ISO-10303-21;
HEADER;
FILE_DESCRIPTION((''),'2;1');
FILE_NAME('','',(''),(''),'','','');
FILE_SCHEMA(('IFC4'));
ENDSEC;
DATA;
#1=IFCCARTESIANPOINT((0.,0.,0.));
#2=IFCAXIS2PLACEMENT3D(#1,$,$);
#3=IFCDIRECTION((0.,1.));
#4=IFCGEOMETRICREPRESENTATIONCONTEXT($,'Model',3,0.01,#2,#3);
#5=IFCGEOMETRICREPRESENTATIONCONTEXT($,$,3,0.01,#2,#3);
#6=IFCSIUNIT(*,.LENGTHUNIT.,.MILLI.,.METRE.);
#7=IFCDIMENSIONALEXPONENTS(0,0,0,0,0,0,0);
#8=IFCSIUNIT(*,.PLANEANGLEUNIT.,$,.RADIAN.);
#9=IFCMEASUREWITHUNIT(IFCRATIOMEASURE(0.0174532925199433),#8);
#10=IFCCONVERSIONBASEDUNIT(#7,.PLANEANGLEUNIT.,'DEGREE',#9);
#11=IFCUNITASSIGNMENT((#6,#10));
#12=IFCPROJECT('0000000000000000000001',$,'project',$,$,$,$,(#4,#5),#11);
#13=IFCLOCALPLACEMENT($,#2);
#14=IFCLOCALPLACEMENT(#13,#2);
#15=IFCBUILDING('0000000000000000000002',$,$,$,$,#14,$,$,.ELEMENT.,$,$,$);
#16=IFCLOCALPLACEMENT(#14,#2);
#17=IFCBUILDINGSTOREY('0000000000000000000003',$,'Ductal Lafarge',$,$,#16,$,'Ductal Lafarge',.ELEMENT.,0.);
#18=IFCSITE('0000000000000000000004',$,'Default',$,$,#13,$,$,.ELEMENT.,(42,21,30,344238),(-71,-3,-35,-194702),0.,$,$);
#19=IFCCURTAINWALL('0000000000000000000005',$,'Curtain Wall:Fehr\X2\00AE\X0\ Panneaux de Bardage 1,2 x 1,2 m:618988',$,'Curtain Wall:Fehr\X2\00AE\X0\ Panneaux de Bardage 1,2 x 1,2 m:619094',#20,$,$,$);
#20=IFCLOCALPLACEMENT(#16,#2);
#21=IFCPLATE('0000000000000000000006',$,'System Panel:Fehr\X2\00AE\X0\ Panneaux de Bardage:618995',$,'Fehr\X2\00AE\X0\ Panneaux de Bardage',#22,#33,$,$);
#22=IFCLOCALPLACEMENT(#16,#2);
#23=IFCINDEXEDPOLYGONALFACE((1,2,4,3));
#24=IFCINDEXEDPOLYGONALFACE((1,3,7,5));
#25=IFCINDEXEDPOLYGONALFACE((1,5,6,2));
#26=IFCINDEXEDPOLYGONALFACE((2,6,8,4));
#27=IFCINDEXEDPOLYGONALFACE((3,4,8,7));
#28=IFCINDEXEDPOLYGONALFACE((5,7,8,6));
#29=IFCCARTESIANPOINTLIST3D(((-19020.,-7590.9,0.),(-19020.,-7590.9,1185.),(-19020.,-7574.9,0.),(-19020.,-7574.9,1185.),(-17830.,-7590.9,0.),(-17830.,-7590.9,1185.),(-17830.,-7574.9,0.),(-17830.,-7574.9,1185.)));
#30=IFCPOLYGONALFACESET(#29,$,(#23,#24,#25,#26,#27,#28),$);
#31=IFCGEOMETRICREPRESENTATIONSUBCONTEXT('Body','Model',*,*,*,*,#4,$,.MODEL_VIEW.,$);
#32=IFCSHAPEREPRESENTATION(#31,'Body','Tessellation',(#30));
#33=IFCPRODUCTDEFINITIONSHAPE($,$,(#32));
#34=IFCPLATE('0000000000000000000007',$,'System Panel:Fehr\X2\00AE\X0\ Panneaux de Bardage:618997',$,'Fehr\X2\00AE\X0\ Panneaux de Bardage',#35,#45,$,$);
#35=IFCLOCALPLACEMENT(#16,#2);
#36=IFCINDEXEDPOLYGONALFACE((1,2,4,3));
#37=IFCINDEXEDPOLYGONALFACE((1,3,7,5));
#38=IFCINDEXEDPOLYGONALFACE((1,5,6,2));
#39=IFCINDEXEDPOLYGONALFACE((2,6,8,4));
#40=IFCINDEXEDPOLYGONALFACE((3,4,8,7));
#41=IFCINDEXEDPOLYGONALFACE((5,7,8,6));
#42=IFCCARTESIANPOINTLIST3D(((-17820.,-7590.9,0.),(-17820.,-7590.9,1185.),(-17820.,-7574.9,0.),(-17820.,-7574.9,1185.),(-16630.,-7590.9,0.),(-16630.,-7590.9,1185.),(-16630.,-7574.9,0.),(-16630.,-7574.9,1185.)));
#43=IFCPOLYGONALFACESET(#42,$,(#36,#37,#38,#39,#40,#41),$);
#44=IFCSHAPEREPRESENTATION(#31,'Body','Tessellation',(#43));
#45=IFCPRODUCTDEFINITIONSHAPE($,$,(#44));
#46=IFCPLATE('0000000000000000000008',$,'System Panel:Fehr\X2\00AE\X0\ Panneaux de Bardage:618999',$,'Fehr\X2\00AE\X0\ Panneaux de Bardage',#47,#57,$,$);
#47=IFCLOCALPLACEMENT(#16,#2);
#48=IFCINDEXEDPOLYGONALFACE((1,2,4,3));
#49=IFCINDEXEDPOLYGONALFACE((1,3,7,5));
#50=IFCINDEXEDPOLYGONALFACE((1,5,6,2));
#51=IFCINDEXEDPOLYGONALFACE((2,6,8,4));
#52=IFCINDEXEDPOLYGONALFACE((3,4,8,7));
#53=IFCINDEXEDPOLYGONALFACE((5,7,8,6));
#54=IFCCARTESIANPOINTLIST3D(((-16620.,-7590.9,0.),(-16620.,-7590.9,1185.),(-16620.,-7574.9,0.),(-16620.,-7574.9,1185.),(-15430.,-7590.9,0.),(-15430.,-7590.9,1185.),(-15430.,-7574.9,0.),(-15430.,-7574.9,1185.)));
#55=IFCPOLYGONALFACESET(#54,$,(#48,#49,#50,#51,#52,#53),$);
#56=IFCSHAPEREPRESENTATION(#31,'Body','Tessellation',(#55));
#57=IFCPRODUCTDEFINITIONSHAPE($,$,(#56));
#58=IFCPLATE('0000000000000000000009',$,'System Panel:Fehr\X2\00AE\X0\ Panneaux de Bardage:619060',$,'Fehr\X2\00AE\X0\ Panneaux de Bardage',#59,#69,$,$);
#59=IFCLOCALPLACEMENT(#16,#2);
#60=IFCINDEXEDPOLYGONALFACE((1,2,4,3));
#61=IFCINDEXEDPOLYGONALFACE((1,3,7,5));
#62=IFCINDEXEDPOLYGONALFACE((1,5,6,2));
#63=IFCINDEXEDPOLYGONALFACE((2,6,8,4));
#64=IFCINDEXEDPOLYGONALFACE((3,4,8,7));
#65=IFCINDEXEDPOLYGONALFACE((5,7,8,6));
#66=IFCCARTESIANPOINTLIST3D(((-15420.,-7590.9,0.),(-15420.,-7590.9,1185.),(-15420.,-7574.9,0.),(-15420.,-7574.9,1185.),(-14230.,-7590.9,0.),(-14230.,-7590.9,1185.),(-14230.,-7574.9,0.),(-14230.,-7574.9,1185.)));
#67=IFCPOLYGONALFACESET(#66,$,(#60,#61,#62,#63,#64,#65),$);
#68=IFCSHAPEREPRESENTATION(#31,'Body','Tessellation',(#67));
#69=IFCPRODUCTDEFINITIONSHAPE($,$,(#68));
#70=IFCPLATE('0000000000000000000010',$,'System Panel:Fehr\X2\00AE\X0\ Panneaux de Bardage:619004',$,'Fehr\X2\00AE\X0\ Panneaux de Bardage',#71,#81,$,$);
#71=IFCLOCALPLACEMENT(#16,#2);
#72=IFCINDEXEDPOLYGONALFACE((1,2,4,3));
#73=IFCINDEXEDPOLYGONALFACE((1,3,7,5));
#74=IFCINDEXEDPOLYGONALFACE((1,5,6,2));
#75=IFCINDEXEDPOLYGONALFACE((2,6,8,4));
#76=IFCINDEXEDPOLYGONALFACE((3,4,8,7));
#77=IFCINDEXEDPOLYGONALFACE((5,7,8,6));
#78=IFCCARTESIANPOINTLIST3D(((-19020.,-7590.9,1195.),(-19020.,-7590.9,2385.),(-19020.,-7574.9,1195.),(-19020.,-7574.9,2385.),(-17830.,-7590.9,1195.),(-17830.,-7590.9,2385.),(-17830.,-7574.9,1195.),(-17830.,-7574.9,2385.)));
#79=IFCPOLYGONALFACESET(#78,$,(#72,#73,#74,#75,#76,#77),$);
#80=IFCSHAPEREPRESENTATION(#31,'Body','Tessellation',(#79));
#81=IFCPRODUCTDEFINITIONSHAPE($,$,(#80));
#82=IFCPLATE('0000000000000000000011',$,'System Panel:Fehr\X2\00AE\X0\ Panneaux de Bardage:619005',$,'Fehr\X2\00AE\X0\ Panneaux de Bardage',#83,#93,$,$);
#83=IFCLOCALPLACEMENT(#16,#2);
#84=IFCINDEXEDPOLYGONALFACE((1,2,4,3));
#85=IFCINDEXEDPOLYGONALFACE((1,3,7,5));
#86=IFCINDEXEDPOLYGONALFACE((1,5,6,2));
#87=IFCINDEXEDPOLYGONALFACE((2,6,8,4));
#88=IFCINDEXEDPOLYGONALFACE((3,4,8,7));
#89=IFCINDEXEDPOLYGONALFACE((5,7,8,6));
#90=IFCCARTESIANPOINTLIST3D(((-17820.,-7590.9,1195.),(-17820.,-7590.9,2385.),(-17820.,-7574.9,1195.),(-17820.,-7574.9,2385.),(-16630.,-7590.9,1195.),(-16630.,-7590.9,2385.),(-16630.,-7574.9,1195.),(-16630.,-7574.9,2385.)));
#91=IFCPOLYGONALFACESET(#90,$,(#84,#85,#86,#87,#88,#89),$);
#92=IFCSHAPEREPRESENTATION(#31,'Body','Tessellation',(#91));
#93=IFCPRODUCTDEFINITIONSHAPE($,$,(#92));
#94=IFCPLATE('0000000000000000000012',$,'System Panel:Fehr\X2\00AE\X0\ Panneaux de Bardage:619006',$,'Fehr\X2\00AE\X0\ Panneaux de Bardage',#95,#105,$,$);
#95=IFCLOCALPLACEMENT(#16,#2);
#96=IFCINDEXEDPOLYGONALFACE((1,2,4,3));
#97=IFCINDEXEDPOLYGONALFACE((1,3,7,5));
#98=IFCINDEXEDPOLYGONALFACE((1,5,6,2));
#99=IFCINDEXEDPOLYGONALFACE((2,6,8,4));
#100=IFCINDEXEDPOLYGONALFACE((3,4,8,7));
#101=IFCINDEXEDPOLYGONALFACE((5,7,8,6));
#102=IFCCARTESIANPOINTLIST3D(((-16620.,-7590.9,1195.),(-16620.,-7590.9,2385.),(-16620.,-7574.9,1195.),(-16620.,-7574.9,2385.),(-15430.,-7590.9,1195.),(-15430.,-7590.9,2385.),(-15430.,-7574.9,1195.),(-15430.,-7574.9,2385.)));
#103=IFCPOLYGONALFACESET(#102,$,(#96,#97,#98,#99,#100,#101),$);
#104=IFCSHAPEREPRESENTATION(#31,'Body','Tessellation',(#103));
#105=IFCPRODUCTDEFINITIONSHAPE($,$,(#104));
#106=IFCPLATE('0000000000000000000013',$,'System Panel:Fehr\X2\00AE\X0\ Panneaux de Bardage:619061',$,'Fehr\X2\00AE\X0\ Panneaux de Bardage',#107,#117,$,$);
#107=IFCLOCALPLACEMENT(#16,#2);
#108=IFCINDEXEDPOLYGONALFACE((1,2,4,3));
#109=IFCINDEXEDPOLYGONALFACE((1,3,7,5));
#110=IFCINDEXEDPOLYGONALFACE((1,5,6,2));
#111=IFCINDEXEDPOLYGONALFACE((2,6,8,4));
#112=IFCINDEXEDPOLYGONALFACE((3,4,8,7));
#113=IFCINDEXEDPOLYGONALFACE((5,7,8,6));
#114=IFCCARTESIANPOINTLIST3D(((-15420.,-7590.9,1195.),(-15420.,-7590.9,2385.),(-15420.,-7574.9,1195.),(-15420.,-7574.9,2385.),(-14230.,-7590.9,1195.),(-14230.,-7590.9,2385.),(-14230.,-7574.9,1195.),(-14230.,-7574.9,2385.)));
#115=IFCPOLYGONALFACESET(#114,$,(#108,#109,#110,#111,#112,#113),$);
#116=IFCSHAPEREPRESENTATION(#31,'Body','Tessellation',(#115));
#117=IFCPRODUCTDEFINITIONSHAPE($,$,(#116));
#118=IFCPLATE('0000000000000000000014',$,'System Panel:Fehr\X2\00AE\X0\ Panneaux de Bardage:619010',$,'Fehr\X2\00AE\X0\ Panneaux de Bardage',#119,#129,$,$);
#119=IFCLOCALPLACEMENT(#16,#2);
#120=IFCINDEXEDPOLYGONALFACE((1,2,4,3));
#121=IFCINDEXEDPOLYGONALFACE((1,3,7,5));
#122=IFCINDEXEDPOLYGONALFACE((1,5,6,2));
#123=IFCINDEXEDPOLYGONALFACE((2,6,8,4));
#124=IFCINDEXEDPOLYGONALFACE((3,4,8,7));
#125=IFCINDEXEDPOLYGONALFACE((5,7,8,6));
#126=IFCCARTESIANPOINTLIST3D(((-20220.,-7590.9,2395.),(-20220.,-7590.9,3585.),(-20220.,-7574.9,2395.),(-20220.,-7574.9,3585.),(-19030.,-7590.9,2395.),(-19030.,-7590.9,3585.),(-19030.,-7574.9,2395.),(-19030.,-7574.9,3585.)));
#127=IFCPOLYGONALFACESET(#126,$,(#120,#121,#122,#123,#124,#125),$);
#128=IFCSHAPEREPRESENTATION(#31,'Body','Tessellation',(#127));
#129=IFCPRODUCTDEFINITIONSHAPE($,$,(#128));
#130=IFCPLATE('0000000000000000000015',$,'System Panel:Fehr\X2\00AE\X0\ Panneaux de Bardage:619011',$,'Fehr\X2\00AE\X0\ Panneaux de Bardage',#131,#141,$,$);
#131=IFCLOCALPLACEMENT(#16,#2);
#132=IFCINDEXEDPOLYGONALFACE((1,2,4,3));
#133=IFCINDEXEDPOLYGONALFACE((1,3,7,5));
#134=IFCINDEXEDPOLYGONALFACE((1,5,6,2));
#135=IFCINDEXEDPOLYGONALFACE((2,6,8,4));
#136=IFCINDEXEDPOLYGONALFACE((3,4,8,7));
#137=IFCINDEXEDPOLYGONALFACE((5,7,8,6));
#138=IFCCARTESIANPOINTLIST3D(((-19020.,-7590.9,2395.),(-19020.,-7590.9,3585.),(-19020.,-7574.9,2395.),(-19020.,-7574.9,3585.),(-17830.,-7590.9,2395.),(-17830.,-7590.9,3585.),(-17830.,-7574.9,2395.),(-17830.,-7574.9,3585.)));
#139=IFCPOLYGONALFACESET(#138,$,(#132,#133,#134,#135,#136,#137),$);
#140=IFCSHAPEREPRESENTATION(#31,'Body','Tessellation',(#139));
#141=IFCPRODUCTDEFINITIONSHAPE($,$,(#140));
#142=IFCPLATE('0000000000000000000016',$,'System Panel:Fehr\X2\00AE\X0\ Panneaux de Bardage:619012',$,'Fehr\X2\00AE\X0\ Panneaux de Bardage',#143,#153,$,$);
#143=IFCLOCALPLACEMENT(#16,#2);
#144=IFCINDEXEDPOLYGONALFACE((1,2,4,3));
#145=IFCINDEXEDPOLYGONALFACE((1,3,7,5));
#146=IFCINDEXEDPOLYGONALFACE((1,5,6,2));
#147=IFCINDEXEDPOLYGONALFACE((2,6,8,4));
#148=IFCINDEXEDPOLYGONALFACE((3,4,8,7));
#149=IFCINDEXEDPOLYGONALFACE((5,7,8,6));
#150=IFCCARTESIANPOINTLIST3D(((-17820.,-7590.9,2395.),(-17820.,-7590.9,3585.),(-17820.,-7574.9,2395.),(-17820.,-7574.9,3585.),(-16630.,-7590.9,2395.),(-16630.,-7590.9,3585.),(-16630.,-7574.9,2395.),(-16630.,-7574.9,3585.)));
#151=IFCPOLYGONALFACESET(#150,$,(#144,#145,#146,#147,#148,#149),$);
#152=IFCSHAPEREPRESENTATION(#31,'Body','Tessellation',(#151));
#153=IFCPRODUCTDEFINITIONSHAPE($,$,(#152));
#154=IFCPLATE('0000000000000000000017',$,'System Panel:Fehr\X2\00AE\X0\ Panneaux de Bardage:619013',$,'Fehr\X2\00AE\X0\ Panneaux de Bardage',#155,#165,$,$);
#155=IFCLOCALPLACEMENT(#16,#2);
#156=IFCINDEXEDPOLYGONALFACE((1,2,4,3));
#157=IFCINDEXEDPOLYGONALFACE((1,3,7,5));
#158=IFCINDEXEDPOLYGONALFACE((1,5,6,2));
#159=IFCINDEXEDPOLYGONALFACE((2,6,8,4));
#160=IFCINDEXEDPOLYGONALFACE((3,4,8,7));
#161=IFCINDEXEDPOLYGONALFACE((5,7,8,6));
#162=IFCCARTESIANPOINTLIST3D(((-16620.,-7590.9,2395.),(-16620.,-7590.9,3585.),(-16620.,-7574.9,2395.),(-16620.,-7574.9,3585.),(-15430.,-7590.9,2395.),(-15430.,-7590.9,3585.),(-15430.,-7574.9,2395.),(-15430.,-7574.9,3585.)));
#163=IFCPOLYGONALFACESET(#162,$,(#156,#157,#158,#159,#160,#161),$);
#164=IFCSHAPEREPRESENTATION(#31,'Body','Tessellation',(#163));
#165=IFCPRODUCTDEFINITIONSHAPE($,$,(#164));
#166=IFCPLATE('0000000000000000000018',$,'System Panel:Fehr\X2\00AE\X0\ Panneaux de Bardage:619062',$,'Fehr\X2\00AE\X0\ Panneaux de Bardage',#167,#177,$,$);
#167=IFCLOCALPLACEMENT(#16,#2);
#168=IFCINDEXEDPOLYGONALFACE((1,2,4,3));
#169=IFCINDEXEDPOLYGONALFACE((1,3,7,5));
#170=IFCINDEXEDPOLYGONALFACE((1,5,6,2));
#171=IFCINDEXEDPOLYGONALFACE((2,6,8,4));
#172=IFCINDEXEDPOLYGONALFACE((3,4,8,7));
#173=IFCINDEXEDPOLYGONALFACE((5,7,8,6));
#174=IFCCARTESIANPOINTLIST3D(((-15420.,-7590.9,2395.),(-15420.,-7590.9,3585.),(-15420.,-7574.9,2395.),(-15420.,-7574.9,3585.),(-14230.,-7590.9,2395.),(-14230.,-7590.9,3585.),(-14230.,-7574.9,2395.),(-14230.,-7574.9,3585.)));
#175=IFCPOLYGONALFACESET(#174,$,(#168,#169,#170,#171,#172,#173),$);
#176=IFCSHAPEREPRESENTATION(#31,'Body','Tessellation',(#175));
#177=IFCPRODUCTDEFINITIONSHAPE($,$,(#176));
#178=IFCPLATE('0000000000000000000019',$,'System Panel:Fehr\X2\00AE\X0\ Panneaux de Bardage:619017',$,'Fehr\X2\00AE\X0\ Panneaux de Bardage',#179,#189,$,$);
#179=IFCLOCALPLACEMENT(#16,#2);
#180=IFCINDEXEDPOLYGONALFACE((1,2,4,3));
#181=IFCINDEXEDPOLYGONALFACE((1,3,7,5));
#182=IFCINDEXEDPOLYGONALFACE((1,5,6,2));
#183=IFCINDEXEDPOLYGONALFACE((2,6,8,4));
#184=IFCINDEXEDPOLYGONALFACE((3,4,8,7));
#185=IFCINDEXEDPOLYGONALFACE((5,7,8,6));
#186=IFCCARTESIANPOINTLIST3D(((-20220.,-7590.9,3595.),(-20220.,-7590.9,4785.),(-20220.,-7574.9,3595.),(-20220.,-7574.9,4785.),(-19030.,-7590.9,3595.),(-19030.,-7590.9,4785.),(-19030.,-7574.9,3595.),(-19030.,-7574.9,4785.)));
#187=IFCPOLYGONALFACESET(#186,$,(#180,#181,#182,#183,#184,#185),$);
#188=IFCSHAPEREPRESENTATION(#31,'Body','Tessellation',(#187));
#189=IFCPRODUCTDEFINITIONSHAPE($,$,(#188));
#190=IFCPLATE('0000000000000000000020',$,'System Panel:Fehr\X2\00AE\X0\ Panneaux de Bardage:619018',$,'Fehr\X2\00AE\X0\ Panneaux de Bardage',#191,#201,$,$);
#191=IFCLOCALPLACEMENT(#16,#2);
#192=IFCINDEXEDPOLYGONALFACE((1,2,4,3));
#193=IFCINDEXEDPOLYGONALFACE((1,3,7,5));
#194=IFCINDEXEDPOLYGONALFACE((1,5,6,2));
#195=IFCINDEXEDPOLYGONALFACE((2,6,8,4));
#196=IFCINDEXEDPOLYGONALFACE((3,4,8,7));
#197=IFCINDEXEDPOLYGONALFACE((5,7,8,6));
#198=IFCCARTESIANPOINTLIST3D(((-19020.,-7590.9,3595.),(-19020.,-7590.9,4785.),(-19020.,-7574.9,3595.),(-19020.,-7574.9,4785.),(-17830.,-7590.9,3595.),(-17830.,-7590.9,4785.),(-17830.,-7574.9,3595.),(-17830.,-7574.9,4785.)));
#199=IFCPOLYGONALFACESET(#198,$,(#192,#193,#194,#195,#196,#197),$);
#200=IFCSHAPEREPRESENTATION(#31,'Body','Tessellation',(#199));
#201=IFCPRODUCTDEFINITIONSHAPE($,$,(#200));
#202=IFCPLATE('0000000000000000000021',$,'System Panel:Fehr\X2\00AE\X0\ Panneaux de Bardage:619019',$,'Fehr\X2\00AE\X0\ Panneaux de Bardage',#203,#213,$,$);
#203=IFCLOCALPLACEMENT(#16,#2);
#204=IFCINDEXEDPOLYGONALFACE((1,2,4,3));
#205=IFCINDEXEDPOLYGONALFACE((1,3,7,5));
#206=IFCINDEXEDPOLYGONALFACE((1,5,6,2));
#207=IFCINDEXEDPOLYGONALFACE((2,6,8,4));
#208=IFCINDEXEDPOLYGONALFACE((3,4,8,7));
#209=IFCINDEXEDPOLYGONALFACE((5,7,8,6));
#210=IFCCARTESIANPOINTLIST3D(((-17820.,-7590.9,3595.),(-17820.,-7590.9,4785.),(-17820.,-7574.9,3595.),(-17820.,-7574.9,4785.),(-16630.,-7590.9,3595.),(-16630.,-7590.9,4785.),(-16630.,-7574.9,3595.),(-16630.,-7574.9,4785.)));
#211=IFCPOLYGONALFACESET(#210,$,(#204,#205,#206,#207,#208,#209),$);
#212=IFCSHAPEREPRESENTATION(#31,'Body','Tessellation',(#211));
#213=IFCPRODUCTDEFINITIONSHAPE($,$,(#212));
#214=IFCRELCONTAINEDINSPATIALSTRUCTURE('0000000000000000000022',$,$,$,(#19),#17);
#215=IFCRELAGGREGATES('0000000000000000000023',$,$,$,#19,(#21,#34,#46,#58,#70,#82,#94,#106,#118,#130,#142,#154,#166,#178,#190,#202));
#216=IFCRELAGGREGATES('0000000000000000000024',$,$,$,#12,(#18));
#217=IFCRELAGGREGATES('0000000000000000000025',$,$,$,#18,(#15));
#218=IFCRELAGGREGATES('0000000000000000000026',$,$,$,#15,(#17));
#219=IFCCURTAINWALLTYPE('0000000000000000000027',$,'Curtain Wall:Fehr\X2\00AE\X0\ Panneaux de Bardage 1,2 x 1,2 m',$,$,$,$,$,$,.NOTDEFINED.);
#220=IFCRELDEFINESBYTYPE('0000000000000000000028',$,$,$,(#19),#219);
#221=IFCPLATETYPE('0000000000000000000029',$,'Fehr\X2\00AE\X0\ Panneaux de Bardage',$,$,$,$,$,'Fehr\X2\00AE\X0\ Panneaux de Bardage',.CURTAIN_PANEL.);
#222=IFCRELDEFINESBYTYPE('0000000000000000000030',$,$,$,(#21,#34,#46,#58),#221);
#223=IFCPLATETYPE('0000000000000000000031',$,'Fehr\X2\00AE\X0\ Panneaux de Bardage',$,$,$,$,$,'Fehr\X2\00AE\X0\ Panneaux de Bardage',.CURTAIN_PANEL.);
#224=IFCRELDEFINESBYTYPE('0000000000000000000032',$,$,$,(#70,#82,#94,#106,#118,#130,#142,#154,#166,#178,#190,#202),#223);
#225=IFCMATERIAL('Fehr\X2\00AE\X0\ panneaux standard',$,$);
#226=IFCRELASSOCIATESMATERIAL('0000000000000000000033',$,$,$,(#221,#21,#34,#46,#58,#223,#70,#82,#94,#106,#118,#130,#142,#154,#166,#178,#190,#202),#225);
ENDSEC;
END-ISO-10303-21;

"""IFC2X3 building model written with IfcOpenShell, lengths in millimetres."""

from ifc_helpers import new_model, entity, si_unit, converted_unit, direction, frame, origin, origin_2d_with_axis, place, context, subcontext, project, spatial, rectangle, extrude, source, transform, mapped, material, type_object, type_shapes, element, aggregate, save


model = new_model("IFC2X3")

# Units and contexts
model_context = context("Model", 3, precision=0.01, world=origin(), true_north=direction((0.0, 1.0)))
context_of_model = context(None, 3, precision=0.01, world=origin(), true_north=direction((0.0, 1.0)))
body_context = subcontext(model_context, "Body", "Model", "MODEL_VIEW")
ifc_project = project(units=[si_unit("LENGTHUNIT", "METRE", prefix="MILLI"), converted_unit("PLANEANGLEUNIT", "DEGREE", entity("IfcRatioMeasure", 0.0174532925199433), si_unit("PLANEANGLEUNIT", "RADIAN"), dimensions=[0, 0, 0, 0, 0, 0, 0])], contexts=[model_context, context_of_model])

# Site, building, storey
site_placement = place(None, origin())
site = spatial("IfcSite", under=ifc_project, at=site_placement, Name="Default", CompositionType="ELEMENT", RefLatitude=(42, 21, 30, 344238), RefLongitude=(-71, -3, -35, -194702), RefElevation=0.0)
building_placement = place(site_placement, origin())
building = spatial("IfcBuilding", under=site, at=building_placement, CompositionType="ELEMENT")
storey_placement = place(building_placement, origin())
storey = spatial("IfcBuildingStorey", under=building, at=storey_placement, Name="Ductal Lafarge", LongName="Ductal Lafarge", CompositionType="ELEMENT", Elevation=0.0)

# Curtain wall, plates
curtain_wall_type = type_object("IfcCurtainWallType", Name="Curtain Wall:Fehr® Panneaux de Bardage 1,2 x 1,2 m", PredefinedType="NOTDEFINED")
curtain_wall_placement = place(storey_placement, origin())
curtain_wall = element("IfcCurtainWall", 1, at=curtain_wall_placement, inside=storey, type_object=curtain_wall_type, Name="Curtain Wall:Fehr® Panneaux de Bardage 1,2 x 1,2 m:618988", ObjectType="Curtain Wall:Fehr® Panneaux de Bardage 1,2 x 1,2 m:619094")
ifc_material_1 = material(Name="Fehr® panneaux standard")
plate_type_1 = type_object("IfcPlateType", Name="Fehr® Panneaux de Bardage", ElementType="Fehr® Panneaux de Bardage", PredefinedType="CURTAIN_PANEL", material=ifc_material_1)
shared_shape_1 = source(origin(), body_context, "Body", "SweptSolid", [
    extrude(rectangle(XDim=16.0, YDim=1190.0, at=origin_2d_with_axis()), frame((0.0, 0.0, 0.0), z_axis=(0.0, 0.0, 1.0), x_axis=(0.0, 1.0, 0.0)), (0.0, 0.0, 1.0), 1185.0),
])
type_shapes(plate_type_1, [shared_shape_1])
plate_1_placement = place(curtain_wall_placement, frame((-18425.0, -7582.9, 0.0)))
plate_1 = element("IfcPlate", 2, at=plate_1_placement, type_object=plate_type_1, material=ifc_material_1, Name="System Panel:Fehr® Panneaux de Bardage:618995", ObjectType="Fehr® Panneaux de Bardage", context=body_context, shape_type="MappedRepresentation", body=[
    mapped(shared_shape_1, transform((0.0, 0.0, 0.0), scale=1.0)),
])
plate_2_placement = place(curtain_wall_placement, frame((-17225.0, -7582.9, 0.0)))
plate_2 = element("IfcPlate", 3, at=plate_2_placement, type_object=plate_type_1, material=ifc_material_1, Name="System Panel:Fehr® Panneaux de Bardage:618997", ObjectType="Fehr® Panneaux de Bardage", context=body_context, shape_type="MappedRepresentation", body=[
    mapped(shared_shape_1, transform((0.0, 0.0, 0.0), scale=1.0)),
])
plate_3_placement = place(curtain_wall_placement, frame((-16025.0, -7582.9, 0.0)))
plate_3 = element("IfcPlate", 4, at=plate_3_placement, type_object=plate_type_1, material=ifc_material_1, Name="System Panel:Fehr® Panneaux de Bardage:618999", ObjectType="Fehr® Panneaux de Bardage", context=body_context, shape_type="MappedRepresentation", body=[
    mapped(shared_shape_1, transform((0.0, 0.0, 0.0), scale=1.0)),
])
plate_4_placement = place(curtain_wall_placement, frame((-14825.0, -7582.9, 0.0)))
plate_4 = element("IfcPlate", 5, at=plate_4_placement, type_object=plate_type_1, material=ifc_material_1, Name="System Panel:Fehr® Panneaux de Bardage:619060", ObjectType="Fehr® Panneaux de Bardage", context=body_context, shape_type="MappedRepresentation", body=[
    mapped(shared_shape_1, transform((0.0, 0.0, 0.0), scale=1.0)),
])
plate_type_2 = type_object("IfcPlateType", Name="Fehr® Panneaux de Bardage", ElementType="Fehr® Panneaux de Bardage", PredefinedType="CURTAIN_PANEL", material=ifc_material_1)
shared_shape_2 = source(origin(), body_context, "Body", "SweptSolid", [
    extrude(rectangle(XDim=16.0, YDim=1190.0, at=origin_2d_with_axis()), frame((0.0, 0.0, 0.0), z_axis=(0.0, 0.0, 1.0), x_axis=(0.0, 1.0, 0.0)), (0.0, 0.0, 1.0), 1190.0),
])
type_shapes(plate_type_2, [shared_shape_2])
plate_5_placement = place(curtain_wall_placement, frame((-18425.0, -7582.9, 1195.0)))
plate_5 = element("IfcPlate", 6, at=plate_5_placement, type_object=plate_type_2, material=ifc_material_1, Name="System Panel:Fehr® Panneaux de Bardage:619004", ObjectType="Fehr® Panneaux de Bardage", context=body_context, shape_type="MappedRepresentation", body=[
    mapped(shared_shape_2, transform((0.0, 0.0, 0.0), scale=1.0)),
])
plate_6_placement = place(curtain_wall_placement, frame((-17225.0, -7582.9, 1195.0)))
plate_6 = element("IfcPlate", 7, at=plate_6_placement, type_object=plate_type_2, material=ifc_material_1, Name="System Panel:Fehr® Panneaux de Bardage:619005", ObjectType="Fehr® Panneaux de Bardage", context=body_context, shape_type="MappedRepresentation", body=[
    mapped(shared_shape_2, transform((0.0, 0.0, 0.0), scale=1.0)),
])
plate_7_placement = place(curtain_wall_placement, frame((-16025.0, -7582.9, 1195.0)))
plate_7 = element("IfcPlate", 8, at=plate_7_placement, type_object=plate_type_2, material=ifc_material_1, Name="System Panel:Fehr® Panneaux de Bardage:619006", ObjectType="Fehr® Panneaux de Bardage", context=body_context, shape_type="MappedRepresentation", body=[
    mapped(shared_shape_2, transform((0.0, 0.0, 0.0), scale=1.0)),
])
plate_8_placement = place(curtain_wall_placement, frame((-14825.0, -7582.9, 1195.0)))
plate_8 = element("IfcPlate", 9, at=plate_8_placement, type_object=plate_type_2, material=ifc_material_1, Name="System Panel:Fehr® Panneaux de Bardage:619061", ObjectType="Fehr® Panneaux de Bardage", context=body_context, shape_type="MappedRepresentation", body=[
    mapped(shared_shape_2, transform((0.0, 0.0, 0.0), scale=1.0)),
])
plate_9_placement = place(curtain_wall_placement, frame((-19625.0, -7582.9, 2395.0)))
plate_9 = element("IfcPlate", 10, at=plate_9_placement, type_object=plate_type_2, material=ifc_material_1, Name="System Panel:Fehr® Panneaux de Bardage:619010", ObjectType="Fehr® Panneaux de Bardage", context=body_context, shape_type="MappedRepresentation", body=[
    mapped(shared_shape_2, transform((0.0, 0.0, 0.0), scale=1.0)),
])
plate_10_placement = place(curtain_wall_placement, frame((-18425.0, -7582.9, 2395.0)))
plate_10 = element("IfcPlate", 11, at=plate_10_placement, type_object=plate_type_2, material=ifc_material_1, Name="System Panel:Fehr® Panneaux de Bardage:619011", ObjectType="Fehr® Panneaux de Bardage", context=body_context, shape_type="MappedRepresentation", body=[
    mapped(shared_shape_2, transform((0.0, 0.0, 0.0), scale=1.0)),
])
plate_11_placement = place(curtain_wall_placement, frame((-17225.0, -7582.9, 2395.0)))
plate_11 = element("IfcPlate", 12, at=plate_11_placement, type_object=plate_type_2, material=ifc_material_1, Name="System Panel:Fehr® Panneaux de Bardage:619012", ObjectType="Fehr® Panneaux de Bardage", context=body_context, shape_type="MappedRepresentation", body=[
    mapped(shared_shape_2, transform((0.0, 0.0, 0.0), scale=1.0)),
])
plate_12_placement = place(curtain_wall_placement, frame((-16025.0, -7582.9, 2395.0)))
plate_12 = element("IfcPlate", 13, at=plate_12_placement, type_object=plate_type_2, material=ifc_material_1, Name="System Panel:Fehr® Panneaux de Bardage:619013", ObjectType="Fehr® Panneaux de Bardage", context=body_context, shape_type="MappedRepresentation", body=[
    mapped(shared_shape_2, transform((0.0, 0.0, 0.0), scale=1.0)),
])
plate_13_placement = place(curtain_wall_placement, frame((-14825.0, -7582.9, 2395.0)))
plate_13 = element("IfcPlate", 14, at=plate_13_placement, type_object=plate_type_2, material=ifc_material_1, Name="System Panel:Fehr® Panneaux de Bardage:619062", ObjectType="Fehr® Panneaux de Bardage", context=body_context, shape_type="MappedRepresentation", body=[
    mapped(shared_shape_2, transform((0.0, 0.0, 0.0), scale=1.0)),
])
plate_14_placement = place(curtain_wall_placement, frame((-19625.0, -7582.9, 3595.0)))
plate_14 = element("IfcPlate", 15, at=plate_14_placement, type_object=plate_type_2, material=ifc_material_1, Name="System Panel:Fehr® Panneaux de Bardage:619017", ObjectType="Fehr® Panneaux de Bardage", context=body_context, shape_type="MappedRepresentation", body=[
    mapped(shared_shape_2, transform((0.0, 0.0, 0.0), scale=1.0)),
])
plate_15_placement = place(curtain_wall_placement, frame((-18425.0, -7582.9, 3595.0)))
plate_15 = element("IfcPlate", 16, at=plate_15_placement, type_object=plate_type_2, material=ifc_material_1, Name="System Panel:Fehr® Panneaux de Bardage:619018", ObjectType="Fehr® Panneaux de Bardage", context=body_context, shape_type="MappedRepresentation", body=[
    mapped(shared_shape_2, transform((0.0, 0.0, 0.0), scale=1.0)),
])
plate_16_placement = place(curtain_wall_placement, frame((-17225.0, -7582.9, 3595.0)))
plate_16 = element("IfcPlate", 17, at=plate_16_placement, type_object=plate_type_2, material=ifc_material_1, Name="System Panel:Fehr® Panneaux de Bardage:619019", ObjectType="Fehr® Panneaux de Bardage", context=body_context, shape_type="MappedRepresentation", body=[
    mapped(shared_shape_2, transform((0.0, 0.0, 0.0), scale=1.0)),
])
aggregate(curtain_wall, [plate_1, plate_2, plate_3, plate_4, plate_5, plate_6, plate_7, plate_8, plate_9, plate_10, plate_11, plate_12, plate_13, plate_14, plate_15, plate_16])

save(model, "model.ifc")
